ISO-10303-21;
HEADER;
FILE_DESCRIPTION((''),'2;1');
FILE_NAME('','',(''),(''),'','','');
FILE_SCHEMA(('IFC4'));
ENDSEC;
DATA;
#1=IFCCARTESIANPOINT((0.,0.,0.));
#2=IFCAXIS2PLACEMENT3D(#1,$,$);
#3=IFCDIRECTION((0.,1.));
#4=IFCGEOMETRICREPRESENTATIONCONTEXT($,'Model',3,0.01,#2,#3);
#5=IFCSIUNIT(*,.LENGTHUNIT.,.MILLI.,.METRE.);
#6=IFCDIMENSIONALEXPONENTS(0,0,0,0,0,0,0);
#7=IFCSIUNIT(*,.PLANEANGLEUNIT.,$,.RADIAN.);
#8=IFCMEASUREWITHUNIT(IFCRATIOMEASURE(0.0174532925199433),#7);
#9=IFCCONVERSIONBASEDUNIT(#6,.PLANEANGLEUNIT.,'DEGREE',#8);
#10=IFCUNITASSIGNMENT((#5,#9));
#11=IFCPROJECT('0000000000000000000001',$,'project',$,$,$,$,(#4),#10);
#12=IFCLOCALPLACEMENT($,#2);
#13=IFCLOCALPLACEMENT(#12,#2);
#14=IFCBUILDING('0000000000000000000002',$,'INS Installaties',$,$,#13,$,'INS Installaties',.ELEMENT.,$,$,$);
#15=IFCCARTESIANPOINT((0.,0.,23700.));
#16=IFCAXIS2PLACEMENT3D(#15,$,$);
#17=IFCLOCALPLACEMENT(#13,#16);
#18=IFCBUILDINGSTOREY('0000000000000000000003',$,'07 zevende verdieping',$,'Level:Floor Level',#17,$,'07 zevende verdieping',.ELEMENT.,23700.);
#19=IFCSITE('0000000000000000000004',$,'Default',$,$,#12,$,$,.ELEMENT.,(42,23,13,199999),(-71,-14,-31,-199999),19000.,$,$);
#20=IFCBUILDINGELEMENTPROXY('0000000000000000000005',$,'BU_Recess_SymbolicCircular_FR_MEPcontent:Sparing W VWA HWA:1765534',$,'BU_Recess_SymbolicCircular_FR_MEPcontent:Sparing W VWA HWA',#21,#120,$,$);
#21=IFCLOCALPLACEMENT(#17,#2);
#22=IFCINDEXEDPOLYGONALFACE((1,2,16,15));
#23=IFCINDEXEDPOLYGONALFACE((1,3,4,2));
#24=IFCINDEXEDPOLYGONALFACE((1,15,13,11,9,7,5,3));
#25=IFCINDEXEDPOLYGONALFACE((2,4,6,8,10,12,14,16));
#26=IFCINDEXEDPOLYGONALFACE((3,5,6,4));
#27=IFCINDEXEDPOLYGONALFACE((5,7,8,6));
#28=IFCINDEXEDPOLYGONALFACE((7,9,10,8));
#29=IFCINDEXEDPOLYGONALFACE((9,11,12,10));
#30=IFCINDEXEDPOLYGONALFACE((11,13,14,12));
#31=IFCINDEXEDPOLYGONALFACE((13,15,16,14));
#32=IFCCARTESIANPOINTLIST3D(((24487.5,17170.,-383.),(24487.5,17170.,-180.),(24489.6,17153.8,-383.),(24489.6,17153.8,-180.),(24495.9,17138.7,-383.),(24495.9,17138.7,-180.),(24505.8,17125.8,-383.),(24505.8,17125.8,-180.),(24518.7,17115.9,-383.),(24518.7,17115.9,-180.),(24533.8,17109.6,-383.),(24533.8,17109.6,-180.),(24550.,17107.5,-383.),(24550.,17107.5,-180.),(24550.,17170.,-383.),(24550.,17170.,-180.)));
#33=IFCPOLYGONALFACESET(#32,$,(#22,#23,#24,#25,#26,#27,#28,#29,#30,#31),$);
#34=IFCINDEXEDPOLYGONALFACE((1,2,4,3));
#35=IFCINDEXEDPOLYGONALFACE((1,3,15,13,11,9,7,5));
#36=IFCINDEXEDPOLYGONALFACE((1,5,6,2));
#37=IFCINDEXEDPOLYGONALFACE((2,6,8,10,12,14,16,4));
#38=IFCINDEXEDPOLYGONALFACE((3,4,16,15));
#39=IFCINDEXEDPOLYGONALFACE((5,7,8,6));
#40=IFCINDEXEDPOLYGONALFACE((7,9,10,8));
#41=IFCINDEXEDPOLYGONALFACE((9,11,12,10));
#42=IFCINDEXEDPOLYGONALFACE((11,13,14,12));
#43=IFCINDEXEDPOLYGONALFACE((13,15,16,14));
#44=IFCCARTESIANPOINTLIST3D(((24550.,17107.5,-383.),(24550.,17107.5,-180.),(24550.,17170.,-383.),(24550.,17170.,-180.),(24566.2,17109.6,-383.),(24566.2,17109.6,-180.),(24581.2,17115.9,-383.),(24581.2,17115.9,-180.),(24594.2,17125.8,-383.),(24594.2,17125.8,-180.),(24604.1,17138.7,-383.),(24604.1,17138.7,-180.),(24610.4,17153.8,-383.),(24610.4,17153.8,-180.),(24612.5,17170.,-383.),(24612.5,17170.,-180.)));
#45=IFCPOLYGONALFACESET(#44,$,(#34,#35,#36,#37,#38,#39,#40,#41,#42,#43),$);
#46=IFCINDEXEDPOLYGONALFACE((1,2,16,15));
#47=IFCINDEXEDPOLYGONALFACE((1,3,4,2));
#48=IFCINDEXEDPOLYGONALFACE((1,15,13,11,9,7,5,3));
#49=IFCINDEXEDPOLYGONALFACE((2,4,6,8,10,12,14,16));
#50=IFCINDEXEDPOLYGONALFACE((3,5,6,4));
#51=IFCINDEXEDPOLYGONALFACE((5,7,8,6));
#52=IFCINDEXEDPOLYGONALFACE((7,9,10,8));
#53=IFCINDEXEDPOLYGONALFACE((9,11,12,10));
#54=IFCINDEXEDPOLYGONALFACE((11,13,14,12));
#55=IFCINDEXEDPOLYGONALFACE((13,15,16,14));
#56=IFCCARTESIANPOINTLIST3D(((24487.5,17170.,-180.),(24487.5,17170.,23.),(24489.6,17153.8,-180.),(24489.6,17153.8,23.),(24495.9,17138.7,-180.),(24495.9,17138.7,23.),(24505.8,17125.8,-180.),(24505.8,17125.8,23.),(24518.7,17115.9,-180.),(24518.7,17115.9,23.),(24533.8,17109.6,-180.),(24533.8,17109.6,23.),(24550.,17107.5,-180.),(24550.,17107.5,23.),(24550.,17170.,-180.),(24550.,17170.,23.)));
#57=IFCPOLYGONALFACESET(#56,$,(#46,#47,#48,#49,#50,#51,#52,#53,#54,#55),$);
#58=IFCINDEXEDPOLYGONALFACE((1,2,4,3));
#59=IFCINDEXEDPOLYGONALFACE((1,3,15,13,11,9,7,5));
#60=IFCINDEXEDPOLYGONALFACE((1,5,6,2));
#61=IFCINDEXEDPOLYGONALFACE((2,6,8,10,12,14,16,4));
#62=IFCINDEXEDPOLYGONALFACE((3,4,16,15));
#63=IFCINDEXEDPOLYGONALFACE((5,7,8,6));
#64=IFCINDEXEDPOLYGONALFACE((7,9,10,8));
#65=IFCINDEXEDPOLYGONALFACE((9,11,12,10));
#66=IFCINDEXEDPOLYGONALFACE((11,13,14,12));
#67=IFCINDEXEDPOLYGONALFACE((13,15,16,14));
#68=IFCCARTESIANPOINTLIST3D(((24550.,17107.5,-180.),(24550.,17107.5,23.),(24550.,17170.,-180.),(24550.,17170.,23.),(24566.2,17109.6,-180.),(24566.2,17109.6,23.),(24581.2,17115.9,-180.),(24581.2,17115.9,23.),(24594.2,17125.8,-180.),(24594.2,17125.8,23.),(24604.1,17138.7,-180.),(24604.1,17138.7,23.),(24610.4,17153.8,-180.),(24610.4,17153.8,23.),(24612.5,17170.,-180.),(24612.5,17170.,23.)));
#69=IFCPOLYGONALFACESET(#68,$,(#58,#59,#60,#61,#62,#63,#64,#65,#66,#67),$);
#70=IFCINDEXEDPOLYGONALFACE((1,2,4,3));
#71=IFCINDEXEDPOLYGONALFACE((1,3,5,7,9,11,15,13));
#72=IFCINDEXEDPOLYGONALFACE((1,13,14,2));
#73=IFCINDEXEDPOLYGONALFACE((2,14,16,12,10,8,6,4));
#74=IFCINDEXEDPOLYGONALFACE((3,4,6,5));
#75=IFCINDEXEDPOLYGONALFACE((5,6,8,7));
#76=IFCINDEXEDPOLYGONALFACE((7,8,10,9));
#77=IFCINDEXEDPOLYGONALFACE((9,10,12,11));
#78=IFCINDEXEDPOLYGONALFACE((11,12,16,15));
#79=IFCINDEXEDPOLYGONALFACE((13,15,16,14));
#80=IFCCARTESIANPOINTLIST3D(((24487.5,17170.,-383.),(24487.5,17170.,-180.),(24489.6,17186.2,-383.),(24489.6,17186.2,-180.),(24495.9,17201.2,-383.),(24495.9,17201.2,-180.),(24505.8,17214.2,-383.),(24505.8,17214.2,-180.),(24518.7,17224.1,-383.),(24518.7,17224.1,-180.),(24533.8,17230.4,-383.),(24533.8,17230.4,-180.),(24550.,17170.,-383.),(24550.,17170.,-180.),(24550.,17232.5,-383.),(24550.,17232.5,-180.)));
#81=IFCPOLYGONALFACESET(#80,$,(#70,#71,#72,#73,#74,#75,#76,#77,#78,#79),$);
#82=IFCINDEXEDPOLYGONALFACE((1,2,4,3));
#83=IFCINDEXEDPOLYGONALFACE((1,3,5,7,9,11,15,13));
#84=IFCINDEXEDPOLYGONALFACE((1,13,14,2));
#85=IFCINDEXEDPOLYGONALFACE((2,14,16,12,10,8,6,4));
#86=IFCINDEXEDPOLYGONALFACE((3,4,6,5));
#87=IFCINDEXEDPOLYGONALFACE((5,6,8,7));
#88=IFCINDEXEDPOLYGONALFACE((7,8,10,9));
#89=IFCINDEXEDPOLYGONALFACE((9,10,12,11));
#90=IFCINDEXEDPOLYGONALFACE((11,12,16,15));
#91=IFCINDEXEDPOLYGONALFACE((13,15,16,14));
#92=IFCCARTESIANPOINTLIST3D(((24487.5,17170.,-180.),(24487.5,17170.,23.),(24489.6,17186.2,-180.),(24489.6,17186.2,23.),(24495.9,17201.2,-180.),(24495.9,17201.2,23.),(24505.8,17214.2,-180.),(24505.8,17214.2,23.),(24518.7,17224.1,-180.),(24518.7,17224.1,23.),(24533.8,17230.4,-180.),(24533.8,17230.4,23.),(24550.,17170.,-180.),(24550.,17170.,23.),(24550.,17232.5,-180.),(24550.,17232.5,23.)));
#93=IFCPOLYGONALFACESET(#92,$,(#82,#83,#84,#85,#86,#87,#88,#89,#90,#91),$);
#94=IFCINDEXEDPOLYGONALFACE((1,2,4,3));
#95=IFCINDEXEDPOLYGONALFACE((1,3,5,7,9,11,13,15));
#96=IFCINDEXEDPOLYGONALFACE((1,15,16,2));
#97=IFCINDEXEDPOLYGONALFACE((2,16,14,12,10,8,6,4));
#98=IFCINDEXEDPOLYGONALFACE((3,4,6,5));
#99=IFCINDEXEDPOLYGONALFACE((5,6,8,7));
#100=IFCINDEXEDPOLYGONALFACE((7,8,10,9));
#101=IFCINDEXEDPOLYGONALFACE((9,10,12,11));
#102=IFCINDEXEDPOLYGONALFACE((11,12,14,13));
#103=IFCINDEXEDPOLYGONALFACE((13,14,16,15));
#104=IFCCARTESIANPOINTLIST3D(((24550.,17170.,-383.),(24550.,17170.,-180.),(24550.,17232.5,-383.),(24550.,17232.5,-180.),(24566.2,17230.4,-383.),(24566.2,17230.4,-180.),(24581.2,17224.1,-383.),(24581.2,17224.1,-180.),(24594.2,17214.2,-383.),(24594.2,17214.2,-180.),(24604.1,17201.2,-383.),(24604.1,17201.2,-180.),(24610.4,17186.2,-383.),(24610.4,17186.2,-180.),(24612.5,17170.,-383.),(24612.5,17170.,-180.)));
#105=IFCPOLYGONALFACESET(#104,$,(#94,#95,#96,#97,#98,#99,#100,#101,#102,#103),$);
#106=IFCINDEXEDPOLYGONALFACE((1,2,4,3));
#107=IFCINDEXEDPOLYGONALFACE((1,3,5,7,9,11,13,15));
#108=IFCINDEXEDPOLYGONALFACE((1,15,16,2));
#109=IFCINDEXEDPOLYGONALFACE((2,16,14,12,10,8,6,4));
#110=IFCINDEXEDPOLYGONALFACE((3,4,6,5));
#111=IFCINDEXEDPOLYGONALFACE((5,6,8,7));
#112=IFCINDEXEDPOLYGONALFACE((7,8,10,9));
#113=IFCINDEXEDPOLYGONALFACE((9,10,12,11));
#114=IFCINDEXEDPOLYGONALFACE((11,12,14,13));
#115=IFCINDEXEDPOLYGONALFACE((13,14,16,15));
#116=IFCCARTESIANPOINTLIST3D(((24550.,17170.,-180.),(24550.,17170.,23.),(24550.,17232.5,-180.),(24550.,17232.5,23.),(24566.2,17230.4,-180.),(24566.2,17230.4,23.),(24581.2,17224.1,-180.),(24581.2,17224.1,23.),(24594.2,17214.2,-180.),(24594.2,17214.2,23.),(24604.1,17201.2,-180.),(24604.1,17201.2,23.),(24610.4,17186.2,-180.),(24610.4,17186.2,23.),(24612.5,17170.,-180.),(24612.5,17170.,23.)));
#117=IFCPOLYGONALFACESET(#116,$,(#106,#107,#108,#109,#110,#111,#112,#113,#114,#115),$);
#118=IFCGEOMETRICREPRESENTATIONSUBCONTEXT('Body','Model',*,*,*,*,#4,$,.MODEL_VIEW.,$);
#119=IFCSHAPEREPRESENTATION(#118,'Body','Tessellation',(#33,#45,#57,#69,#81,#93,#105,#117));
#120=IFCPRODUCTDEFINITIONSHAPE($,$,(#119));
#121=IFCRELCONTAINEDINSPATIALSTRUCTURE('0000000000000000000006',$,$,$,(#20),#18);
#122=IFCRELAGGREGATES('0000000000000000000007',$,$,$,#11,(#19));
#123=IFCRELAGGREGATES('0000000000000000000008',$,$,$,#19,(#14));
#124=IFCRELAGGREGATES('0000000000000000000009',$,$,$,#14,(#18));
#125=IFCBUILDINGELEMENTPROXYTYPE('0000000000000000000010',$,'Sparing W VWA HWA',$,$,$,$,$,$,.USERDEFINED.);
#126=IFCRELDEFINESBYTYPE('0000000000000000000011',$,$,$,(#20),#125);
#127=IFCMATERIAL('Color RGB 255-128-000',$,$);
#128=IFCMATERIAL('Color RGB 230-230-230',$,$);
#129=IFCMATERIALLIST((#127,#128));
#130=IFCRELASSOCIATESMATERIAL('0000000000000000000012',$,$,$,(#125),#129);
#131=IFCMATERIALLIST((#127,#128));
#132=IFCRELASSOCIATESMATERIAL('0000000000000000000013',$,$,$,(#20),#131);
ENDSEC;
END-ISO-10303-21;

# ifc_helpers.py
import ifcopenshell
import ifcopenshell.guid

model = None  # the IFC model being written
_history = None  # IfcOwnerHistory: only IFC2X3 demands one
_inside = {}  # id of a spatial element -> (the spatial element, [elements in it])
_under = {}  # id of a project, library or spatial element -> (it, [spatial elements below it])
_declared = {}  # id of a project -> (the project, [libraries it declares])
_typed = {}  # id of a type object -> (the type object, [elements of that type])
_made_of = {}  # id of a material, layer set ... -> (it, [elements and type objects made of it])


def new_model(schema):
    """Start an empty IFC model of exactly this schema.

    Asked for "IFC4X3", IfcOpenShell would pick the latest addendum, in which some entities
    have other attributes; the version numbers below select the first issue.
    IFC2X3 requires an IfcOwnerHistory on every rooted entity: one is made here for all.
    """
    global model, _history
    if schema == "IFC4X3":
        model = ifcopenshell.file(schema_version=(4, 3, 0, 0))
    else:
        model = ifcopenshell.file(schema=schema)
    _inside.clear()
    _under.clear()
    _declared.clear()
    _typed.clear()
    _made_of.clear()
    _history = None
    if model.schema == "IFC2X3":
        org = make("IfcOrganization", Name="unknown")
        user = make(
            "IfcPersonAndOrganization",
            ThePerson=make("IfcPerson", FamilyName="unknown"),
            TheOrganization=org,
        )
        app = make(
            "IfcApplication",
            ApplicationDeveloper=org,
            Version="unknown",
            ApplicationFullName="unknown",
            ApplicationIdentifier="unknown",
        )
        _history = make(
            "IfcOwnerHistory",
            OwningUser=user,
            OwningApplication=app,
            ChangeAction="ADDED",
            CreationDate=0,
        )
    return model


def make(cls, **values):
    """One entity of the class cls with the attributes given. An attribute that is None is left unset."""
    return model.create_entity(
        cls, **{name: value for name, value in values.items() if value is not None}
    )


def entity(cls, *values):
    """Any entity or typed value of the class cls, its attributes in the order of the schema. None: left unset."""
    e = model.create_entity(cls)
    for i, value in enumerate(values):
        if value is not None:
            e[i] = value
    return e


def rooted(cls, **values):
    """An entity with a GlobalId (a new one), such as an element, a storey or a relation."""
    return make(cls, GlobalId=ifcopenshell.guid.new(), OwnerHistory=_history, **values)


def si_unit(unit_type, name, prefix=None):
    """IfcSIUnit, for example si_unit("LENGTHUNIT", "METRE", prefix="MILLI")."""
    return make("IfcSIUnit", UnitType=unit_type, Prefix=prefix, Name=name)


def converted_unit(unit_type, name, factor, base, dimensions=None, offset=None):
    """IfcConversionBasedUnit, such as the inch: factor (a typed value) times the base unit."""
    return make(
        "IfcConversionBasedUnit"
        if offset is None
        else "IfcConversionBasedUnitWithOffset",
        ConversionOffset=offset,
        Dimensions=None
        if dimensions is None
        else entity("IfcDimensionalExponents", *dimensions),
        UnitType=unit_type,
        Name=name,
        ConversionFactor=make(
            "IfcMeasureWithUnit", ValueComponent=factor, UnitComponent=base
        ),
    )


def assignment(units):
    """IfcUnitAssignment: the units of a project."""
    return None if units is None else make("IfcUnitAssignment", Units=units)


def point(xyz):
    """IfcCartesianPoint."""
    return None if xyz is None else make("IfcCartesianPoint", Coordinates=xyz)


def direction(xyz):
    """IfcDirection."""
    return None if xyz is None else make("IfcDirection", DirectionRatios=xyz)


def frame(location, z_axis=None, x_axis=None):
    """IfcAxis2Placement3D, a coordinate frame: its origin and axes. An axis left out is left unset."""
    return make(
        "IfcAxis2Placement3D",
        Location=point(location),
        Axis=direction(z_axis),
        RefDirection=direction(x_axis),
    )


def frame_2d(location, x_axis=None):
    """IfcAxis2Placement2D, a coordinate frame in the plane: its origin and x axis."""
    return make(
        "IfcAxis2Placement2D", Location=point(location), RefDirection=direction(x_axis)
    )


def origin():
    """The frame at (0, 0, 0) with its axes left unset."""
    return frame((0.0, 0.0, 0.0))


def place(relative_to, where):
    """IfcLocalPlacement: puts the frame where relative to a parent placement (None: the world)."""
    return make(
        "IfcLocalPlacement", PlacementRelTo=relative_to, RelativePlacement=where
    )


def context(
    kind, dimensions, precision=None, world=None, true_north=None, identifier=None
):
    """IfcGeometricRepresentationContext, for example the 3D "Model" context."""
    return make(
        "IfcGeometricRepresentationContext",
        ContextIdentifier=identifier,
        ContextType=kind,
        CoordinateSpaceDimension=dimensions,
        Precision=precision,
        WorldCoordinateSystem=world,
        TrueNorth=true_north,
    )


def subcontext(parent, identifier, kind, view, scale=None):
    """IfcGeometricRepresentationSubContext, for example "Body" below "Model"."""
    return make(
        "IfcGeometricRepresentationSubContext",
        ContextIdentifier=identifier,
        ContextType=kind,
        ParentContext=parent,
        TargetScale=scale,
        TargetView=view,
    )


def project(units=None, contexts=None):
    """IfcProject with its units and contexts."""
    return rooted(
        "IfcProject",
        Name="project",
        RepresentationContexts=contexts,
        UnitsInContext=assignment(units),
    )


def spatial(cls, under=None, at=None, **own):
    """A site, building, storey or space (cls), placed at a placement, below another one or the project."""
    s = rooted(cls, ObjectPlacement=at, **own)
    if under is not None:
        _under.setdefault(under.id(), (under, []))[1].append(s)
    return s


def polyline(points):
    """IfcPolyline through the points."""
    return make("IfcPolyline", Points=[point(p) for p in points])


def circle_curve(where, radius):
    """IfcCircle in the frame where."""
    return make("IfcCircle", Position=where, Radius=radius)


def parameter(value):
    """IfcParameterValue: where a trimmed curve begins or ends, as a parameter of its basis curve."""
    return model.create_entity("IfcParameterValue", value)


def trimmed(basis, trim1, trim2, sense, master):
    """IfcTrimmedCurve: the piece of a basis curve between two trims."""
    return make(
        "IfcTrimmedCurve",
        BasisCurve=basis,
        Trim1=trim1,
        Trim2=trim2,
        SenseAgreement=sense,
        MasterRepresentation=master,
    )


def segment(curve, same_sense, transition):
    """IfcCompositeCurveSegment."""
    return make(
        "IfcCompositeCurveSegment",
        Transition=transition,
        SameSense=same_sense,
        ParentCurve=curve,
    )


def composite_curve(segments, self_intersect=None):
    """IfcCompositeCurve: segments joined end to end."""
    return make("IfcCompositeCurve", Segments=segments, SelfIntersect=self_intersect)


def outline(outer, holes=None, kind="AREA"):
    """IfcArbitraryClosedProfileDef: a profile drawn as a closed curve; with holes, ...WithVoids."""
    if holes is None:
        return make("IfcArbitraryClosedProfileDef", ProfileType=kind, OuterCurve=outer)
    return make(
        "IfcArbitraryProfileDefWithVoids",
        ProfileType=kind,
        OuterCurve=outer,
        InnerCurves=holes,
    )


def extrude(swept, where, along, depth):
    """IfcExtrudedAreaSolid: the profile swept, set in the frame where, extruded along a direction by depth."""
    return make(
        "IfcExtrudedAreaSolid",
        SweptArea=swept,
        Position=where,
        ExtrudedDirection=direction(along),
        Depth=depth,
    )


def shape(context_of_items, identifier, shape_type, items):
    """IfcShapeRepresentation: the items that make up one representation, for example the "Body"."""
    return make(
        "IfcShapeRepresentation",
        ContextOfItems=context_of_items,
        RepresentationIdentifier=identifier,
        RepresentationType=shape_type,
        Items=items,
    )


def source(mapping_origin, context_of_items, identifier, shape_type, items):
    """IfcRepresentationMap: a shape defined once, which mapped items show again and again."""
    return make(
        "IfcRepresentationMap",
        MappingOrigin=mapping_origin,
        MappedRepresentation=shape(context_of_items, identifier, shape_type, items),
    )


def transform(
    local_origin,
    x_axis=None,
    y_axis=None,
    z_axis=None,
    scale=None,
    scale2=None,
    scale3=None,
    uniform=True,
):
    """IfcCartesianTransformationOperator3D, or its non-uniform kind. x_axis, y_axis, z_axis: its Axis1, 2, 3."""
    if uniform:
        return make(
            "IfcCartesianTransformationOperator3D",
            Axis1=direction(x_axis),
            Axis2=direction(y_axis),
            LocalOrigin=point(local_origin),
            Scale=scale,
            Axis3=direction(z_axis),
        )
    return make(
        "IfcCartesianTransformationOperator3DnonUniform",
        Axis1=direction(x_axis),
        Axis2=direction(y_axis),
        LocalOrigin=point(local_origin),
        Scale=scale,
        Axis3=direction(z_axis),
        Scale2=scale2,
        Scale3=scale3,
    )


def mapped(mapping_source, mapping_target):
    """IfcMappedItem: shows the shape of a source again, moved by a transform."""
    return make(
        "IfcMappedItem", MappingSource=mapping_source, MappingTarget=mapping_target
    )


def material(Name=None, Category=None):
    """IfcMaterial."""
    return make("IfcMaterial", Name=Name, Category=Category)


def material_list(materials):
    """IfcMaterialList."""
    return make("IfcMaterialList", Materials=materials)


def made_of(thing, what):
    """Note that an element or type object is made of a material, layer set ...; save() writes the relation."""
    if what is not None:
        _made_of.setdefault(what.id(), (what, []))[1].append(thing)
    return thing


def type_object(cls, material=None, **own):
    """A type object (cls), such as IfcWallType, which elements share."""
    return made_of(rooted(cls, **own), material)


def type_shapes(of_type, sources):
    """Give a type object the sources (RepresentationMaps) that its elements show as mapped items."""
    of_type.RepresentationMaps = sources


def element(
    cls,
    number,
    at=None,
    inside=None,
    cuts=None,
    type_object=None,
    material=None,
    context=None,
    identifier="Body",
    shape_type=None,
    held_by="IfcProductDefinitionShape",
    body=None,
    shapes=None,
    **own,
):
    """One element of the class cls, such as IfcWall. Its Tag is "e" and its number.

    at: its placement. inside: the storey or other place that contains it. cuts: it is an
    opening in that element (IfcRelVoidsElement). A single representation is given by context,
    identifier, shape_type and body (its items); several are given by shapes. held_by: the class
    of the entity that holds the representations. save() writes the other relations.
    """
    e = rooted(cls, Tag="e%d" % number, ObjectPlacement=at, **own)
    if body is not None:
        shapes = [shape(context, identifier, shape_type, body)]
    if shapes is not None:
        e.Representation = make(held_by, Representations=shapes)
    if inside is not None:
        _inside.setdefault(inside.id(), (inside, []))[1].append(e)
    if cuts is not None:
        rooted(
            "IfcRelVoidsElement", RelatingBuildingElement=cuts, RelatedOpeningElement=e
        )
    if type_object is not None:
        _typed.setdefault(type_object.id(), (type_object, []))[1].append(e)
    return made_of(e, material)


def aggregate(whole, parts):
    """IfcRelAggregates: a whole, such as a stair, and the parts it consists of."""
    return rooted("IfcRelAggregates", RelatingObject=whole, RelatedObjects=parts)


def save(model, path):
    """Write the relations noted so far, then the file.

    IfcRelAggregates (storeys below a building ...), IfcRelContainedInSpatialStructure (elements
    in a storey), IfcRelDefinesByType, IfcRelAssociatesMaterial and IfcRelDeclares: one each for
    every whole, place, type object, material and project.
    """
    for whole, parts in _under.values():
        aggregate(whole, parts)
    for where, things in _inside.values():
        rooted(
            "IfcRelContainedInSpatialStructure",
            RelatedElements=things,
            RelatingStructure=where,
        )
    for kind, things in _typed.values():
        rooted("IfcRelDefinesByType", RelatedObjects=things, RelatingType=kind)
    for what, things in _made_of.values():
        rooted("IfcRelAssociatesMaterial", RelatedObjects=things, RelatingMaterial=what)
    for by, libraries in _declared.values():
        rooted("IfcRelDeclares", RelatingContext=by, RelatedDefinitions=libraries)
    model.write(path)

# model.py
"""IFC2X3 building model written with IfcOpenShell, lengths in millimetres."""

from ifc_helpers import new_model, entity, si_unit, converted_unit, direction, frame, frame_2d, origin, place, context, subcontext, project, spatial, polyline, circle_curve, parameter, trimmed, segment, composite_curve, outline, extrude, source, transform, mapped, material, material_list, type_object, type_shapes, element, save


model = new_model("IFC2X3")

# Units and contexts
model_context = context("Model", 3, precision=0.01, world=origin(), true_north=direction((0.0, 1.0)))
body_context = subcontext(model_context, "Body", "Model", "MODEL_VIEW")
ifc_project = project(units=[si_unit("LENGTHUNIT", "METRE", prefix="MILLI"), converted_unit("PLANEANGLEUNIT", "DEGREE", entity("IfcRatioMeasure", 0.0174532925199433), si_unit("PLANEANGLEUNIT", "RADIAN"), dimensions=[0, 0, 0, 0, 0, 0, 0])], contexts=[model_context])

# Site, building, storey
site_placement = place(None, origin())
site = spatial("IfcSite", under=ifc_project, at=site_placement, Name="Default", CompositionType="ELEMENT", RefLatitude=(42, 23, 13, 199999), RefLongitude=(-71, -14, -31, -199999), RefElevation=19000.0)
building_placement = place(site_placement, origin())
building = spatial("IfcBuilding", under=site, at=building_placement, Name="INS Installaties", LongName="INS Installaties", CompositionType="ELEMENT")
storey_placement = place(building_placement, frame((0.0, 0.0, 23700.0)))
storey = spatial("IfcBuildingStorey", under=building, at=storey_placement, Name="07 zevende verdieping", ObjectType="Level:Floor Level", LongName="07 zevende verdieping", CompositionType="ELEMENT", Elevation=23700.0)

# Building element proxy
ifc_material_1 = material(Name="Color RGB 255-128-000")
ifc_material_2 = material(Name="Color RGB 230-230-230")
ifc_material_list_1 = material_list([ifc_material_1, ifc_material_2])
building_element_proxy_type_1 = type_object("IfcBuildingElementProxyType", Name="Sparing W VWA HWA", PredefinedType="USERDEFINED", material=ifc_material_list_1)
shared_shape_1 = source(origin(), body_context, "Body", "SweptSolid", [
    extrude(outline(composite_curve([segment(trimmed(circle_curve(frame_2d((20.8, 20.8), x_axis=(1.0, 0.0)), 62.5), [parameter(180.0)], [parameter(270.0)], True, "PARAMETER"), True, "CONTINUOUS"), segment(polyline([(20.8, -41.7), (20.8, 20.8)]), True, "CONTINUOUS"), segment(polyline([(20.8, 20.8), (-41.7, 20.8)]), True, "CONTINUOUS")], self_intersect=False)), frame((20.8, 20.8, -403.0), z_axis=(0.0, 0.0, 1.0), x_axis=(-1.0, 0.0, 0.0)), (0.0, 0.0, 1.0), 203.0),
    extrude(outline(composite_curve([segment(polyline([(-41.7, -20.8), (20.8, -20.8)]), True, "CONTINUOUS"), segment(polyline([(20.8, -20.8), (20.8, 41.7)]), True, "CONTINUOUS"), segment(trimmed(circle_curve(frame_2d((20.8, -20.8), x_axis=(1.0, 0.0)), 62.5), [parameter(90.0)], [parameter(180.0)], True, "PARAMETER"), True, "CONTINUOUS")], self_intersect=False)), frame((-20.8, 20.8, -403.0)), (0.0, 0.0, 1.0), 203.0),
    extrude(outline(composite_curve([segment(trimmed(circle_curve(frame_2d((20.8, 20.8), x_axis=(1.0, 0.0)), 62.5), [parameter(180.0)], [parameter(270.0)], True, "PARAMETER"), True, "CONTINUOUS"), segment(polyline([(20.8, -41.7), (20.8, 20.8)]), True, "CONTINUOUS"), segment(polyline([(20.8, 20.8), (-41.7, 20.8)]), True, "CONTINUOUS")], self_intersect=False)), frame((20.8, 20.8, -200.0), z_axis=(0.0, 0.0, 1.0), x_axis=(-1.0, 0.0, 0.0)), (0.0, 0.0, 1.0), 203.0),
    extrude(outline(composite_curve([segment(polyline([(-41.7, -20.8), (20.8, -20.8)]), True, "CONTINUOUS"), segment(polyline([(20.8, -20.8), (20.8, 41.7)]), True, "CONTINUOUS"), segment(trimmed(circle_curve(frame_2d((20.8, -20.8), x_axis=(1.0, 0.0)), 62.5), [parameter(90.0)], [parameter(180.0)], True, "PARAMETER"), True, "CONTINUOUS")], self_intersect=False)), frame((-20.8, 20.8, -200.0)), (0.0, 0.0, 1.0), 203.0),
    extrude(outline(composite_curve([segment(polyline([(-41.7, -20.8), (20.8, -20.8)]), True, "CONTINUOUS"), segment(polyline([(20.8, -20.8), (20.8, 41.7)]), True, "CONTINUOUS"), segment(trimmed(circle_curve(frame_2d((20.8, -20.8), x_axis=(1.0, 0.0)), 62.5), [parameter(90.0)], [parameter(180.0)], True, "PARAMETER"), True, "CONTINUOUS")], self_intersect=False)), frame((20.8, -20.8, -403.0), z_axis=(0.0, 0.0, 1.0), x_axis=(-1.0, 0.0, 0.0)), (0.0, 0.0, 1.0), 203.0),
    extrude(outline(composite_curve([segment(polyline([(-41.7, -20.8), (20.8, -20.8)]), True, "CONTINUOUS"), segment(polyline([(20.8, -20.8), (20.8, 41.7)]), True, "CONTINUOUS"), segment(trimmed(circle_curve(frame_2d((20.8, -20.8), x_axis=(1.0, 0.0)), 62.5), [parameter(90.0)], [parameter(180.0)], True, "PARAMETER"), True, "CONTINUOUS")], self_intersect=False)), frame((20.8, -20.8, -200.0), z_axis=(0.0, 0.0, 1.0), x_axis=(-1.0, 0.0, 0.0)), (0.0, 0.0, 1.0), 203.0),
    extrude(outline(composite_curve([segment(trimmed(circle_curve(frame_2d((20.8, 20.8), x_axis=(1.0, 0.0)), 62.5), [parameter(180.0)], [parameter(270.0)], True, "PARAMETER"), True, "CONTINUOUS"), segment(polyline([(20.8, -41.7), (20.8, 20.8)]), True, "CONTINUOUS"), segment(polyline([(20.8, 20.8), (-41.7, 20.8)]), True, "CONTINUOUS")], self_intersect=False)), frame((-20.8, -20.8, -403.0)), (0.0, 0.0, 1.0), 203.0),
    extrude(outline(composite_curve([segment(trimmed(circle_curve(frame_2d((20.8, 20.8), x_axis=(1.0, 0.0)), 62.5), [parameter(180.0)], [parameter(270.0)], True, "PARAMETER"), True, "CONTINUOUS"), segment(polyline([(20.8, -41.7), (20.8, 20.8)]), True, "CONTINUOUS"), segment(polyline([(20.8, 20.8), (-41.7, 20.8)]), True, "CONTINUOUS")], self_intersect=False)), frame((-20.8, -20.8, -200.0)), (0.0, 0.0, 1.0), 203.0),
])
type_shapes(building_element_proxy_type_1, [shared_shape_1])
ifc_material_list_2 = material_list([ifc_material_1, ifc_material_2])
proxy_1_placement = place(storey_placement, frame((24550.0, 17170.0, 20.0), z_axis=(0.0, 0.0, 1.0), x_axis=(-1.0, 0.0, 0.0)))
element("IfcBuildingElementProxy", 1, at=proxy_1_placement, inside=storey, type_object=building_element_proxy_type_1, material=ifc_material_list_2, Name="BU_Recess_SymbolicCircular_FR_MEPcontent:Sparing W VWA HWA:1765534", ObjectType="BU_Recess_SymbolicCircular_FR_MEPcontent:Sparing W VWA HWA", context=body_context, shape_type="MappedRepresentation", body=[
    mapped(shared_shape_1, transform((0.0, 0.0, 0.0), scale=1.0)),
])

save(model, "model.ifc")
